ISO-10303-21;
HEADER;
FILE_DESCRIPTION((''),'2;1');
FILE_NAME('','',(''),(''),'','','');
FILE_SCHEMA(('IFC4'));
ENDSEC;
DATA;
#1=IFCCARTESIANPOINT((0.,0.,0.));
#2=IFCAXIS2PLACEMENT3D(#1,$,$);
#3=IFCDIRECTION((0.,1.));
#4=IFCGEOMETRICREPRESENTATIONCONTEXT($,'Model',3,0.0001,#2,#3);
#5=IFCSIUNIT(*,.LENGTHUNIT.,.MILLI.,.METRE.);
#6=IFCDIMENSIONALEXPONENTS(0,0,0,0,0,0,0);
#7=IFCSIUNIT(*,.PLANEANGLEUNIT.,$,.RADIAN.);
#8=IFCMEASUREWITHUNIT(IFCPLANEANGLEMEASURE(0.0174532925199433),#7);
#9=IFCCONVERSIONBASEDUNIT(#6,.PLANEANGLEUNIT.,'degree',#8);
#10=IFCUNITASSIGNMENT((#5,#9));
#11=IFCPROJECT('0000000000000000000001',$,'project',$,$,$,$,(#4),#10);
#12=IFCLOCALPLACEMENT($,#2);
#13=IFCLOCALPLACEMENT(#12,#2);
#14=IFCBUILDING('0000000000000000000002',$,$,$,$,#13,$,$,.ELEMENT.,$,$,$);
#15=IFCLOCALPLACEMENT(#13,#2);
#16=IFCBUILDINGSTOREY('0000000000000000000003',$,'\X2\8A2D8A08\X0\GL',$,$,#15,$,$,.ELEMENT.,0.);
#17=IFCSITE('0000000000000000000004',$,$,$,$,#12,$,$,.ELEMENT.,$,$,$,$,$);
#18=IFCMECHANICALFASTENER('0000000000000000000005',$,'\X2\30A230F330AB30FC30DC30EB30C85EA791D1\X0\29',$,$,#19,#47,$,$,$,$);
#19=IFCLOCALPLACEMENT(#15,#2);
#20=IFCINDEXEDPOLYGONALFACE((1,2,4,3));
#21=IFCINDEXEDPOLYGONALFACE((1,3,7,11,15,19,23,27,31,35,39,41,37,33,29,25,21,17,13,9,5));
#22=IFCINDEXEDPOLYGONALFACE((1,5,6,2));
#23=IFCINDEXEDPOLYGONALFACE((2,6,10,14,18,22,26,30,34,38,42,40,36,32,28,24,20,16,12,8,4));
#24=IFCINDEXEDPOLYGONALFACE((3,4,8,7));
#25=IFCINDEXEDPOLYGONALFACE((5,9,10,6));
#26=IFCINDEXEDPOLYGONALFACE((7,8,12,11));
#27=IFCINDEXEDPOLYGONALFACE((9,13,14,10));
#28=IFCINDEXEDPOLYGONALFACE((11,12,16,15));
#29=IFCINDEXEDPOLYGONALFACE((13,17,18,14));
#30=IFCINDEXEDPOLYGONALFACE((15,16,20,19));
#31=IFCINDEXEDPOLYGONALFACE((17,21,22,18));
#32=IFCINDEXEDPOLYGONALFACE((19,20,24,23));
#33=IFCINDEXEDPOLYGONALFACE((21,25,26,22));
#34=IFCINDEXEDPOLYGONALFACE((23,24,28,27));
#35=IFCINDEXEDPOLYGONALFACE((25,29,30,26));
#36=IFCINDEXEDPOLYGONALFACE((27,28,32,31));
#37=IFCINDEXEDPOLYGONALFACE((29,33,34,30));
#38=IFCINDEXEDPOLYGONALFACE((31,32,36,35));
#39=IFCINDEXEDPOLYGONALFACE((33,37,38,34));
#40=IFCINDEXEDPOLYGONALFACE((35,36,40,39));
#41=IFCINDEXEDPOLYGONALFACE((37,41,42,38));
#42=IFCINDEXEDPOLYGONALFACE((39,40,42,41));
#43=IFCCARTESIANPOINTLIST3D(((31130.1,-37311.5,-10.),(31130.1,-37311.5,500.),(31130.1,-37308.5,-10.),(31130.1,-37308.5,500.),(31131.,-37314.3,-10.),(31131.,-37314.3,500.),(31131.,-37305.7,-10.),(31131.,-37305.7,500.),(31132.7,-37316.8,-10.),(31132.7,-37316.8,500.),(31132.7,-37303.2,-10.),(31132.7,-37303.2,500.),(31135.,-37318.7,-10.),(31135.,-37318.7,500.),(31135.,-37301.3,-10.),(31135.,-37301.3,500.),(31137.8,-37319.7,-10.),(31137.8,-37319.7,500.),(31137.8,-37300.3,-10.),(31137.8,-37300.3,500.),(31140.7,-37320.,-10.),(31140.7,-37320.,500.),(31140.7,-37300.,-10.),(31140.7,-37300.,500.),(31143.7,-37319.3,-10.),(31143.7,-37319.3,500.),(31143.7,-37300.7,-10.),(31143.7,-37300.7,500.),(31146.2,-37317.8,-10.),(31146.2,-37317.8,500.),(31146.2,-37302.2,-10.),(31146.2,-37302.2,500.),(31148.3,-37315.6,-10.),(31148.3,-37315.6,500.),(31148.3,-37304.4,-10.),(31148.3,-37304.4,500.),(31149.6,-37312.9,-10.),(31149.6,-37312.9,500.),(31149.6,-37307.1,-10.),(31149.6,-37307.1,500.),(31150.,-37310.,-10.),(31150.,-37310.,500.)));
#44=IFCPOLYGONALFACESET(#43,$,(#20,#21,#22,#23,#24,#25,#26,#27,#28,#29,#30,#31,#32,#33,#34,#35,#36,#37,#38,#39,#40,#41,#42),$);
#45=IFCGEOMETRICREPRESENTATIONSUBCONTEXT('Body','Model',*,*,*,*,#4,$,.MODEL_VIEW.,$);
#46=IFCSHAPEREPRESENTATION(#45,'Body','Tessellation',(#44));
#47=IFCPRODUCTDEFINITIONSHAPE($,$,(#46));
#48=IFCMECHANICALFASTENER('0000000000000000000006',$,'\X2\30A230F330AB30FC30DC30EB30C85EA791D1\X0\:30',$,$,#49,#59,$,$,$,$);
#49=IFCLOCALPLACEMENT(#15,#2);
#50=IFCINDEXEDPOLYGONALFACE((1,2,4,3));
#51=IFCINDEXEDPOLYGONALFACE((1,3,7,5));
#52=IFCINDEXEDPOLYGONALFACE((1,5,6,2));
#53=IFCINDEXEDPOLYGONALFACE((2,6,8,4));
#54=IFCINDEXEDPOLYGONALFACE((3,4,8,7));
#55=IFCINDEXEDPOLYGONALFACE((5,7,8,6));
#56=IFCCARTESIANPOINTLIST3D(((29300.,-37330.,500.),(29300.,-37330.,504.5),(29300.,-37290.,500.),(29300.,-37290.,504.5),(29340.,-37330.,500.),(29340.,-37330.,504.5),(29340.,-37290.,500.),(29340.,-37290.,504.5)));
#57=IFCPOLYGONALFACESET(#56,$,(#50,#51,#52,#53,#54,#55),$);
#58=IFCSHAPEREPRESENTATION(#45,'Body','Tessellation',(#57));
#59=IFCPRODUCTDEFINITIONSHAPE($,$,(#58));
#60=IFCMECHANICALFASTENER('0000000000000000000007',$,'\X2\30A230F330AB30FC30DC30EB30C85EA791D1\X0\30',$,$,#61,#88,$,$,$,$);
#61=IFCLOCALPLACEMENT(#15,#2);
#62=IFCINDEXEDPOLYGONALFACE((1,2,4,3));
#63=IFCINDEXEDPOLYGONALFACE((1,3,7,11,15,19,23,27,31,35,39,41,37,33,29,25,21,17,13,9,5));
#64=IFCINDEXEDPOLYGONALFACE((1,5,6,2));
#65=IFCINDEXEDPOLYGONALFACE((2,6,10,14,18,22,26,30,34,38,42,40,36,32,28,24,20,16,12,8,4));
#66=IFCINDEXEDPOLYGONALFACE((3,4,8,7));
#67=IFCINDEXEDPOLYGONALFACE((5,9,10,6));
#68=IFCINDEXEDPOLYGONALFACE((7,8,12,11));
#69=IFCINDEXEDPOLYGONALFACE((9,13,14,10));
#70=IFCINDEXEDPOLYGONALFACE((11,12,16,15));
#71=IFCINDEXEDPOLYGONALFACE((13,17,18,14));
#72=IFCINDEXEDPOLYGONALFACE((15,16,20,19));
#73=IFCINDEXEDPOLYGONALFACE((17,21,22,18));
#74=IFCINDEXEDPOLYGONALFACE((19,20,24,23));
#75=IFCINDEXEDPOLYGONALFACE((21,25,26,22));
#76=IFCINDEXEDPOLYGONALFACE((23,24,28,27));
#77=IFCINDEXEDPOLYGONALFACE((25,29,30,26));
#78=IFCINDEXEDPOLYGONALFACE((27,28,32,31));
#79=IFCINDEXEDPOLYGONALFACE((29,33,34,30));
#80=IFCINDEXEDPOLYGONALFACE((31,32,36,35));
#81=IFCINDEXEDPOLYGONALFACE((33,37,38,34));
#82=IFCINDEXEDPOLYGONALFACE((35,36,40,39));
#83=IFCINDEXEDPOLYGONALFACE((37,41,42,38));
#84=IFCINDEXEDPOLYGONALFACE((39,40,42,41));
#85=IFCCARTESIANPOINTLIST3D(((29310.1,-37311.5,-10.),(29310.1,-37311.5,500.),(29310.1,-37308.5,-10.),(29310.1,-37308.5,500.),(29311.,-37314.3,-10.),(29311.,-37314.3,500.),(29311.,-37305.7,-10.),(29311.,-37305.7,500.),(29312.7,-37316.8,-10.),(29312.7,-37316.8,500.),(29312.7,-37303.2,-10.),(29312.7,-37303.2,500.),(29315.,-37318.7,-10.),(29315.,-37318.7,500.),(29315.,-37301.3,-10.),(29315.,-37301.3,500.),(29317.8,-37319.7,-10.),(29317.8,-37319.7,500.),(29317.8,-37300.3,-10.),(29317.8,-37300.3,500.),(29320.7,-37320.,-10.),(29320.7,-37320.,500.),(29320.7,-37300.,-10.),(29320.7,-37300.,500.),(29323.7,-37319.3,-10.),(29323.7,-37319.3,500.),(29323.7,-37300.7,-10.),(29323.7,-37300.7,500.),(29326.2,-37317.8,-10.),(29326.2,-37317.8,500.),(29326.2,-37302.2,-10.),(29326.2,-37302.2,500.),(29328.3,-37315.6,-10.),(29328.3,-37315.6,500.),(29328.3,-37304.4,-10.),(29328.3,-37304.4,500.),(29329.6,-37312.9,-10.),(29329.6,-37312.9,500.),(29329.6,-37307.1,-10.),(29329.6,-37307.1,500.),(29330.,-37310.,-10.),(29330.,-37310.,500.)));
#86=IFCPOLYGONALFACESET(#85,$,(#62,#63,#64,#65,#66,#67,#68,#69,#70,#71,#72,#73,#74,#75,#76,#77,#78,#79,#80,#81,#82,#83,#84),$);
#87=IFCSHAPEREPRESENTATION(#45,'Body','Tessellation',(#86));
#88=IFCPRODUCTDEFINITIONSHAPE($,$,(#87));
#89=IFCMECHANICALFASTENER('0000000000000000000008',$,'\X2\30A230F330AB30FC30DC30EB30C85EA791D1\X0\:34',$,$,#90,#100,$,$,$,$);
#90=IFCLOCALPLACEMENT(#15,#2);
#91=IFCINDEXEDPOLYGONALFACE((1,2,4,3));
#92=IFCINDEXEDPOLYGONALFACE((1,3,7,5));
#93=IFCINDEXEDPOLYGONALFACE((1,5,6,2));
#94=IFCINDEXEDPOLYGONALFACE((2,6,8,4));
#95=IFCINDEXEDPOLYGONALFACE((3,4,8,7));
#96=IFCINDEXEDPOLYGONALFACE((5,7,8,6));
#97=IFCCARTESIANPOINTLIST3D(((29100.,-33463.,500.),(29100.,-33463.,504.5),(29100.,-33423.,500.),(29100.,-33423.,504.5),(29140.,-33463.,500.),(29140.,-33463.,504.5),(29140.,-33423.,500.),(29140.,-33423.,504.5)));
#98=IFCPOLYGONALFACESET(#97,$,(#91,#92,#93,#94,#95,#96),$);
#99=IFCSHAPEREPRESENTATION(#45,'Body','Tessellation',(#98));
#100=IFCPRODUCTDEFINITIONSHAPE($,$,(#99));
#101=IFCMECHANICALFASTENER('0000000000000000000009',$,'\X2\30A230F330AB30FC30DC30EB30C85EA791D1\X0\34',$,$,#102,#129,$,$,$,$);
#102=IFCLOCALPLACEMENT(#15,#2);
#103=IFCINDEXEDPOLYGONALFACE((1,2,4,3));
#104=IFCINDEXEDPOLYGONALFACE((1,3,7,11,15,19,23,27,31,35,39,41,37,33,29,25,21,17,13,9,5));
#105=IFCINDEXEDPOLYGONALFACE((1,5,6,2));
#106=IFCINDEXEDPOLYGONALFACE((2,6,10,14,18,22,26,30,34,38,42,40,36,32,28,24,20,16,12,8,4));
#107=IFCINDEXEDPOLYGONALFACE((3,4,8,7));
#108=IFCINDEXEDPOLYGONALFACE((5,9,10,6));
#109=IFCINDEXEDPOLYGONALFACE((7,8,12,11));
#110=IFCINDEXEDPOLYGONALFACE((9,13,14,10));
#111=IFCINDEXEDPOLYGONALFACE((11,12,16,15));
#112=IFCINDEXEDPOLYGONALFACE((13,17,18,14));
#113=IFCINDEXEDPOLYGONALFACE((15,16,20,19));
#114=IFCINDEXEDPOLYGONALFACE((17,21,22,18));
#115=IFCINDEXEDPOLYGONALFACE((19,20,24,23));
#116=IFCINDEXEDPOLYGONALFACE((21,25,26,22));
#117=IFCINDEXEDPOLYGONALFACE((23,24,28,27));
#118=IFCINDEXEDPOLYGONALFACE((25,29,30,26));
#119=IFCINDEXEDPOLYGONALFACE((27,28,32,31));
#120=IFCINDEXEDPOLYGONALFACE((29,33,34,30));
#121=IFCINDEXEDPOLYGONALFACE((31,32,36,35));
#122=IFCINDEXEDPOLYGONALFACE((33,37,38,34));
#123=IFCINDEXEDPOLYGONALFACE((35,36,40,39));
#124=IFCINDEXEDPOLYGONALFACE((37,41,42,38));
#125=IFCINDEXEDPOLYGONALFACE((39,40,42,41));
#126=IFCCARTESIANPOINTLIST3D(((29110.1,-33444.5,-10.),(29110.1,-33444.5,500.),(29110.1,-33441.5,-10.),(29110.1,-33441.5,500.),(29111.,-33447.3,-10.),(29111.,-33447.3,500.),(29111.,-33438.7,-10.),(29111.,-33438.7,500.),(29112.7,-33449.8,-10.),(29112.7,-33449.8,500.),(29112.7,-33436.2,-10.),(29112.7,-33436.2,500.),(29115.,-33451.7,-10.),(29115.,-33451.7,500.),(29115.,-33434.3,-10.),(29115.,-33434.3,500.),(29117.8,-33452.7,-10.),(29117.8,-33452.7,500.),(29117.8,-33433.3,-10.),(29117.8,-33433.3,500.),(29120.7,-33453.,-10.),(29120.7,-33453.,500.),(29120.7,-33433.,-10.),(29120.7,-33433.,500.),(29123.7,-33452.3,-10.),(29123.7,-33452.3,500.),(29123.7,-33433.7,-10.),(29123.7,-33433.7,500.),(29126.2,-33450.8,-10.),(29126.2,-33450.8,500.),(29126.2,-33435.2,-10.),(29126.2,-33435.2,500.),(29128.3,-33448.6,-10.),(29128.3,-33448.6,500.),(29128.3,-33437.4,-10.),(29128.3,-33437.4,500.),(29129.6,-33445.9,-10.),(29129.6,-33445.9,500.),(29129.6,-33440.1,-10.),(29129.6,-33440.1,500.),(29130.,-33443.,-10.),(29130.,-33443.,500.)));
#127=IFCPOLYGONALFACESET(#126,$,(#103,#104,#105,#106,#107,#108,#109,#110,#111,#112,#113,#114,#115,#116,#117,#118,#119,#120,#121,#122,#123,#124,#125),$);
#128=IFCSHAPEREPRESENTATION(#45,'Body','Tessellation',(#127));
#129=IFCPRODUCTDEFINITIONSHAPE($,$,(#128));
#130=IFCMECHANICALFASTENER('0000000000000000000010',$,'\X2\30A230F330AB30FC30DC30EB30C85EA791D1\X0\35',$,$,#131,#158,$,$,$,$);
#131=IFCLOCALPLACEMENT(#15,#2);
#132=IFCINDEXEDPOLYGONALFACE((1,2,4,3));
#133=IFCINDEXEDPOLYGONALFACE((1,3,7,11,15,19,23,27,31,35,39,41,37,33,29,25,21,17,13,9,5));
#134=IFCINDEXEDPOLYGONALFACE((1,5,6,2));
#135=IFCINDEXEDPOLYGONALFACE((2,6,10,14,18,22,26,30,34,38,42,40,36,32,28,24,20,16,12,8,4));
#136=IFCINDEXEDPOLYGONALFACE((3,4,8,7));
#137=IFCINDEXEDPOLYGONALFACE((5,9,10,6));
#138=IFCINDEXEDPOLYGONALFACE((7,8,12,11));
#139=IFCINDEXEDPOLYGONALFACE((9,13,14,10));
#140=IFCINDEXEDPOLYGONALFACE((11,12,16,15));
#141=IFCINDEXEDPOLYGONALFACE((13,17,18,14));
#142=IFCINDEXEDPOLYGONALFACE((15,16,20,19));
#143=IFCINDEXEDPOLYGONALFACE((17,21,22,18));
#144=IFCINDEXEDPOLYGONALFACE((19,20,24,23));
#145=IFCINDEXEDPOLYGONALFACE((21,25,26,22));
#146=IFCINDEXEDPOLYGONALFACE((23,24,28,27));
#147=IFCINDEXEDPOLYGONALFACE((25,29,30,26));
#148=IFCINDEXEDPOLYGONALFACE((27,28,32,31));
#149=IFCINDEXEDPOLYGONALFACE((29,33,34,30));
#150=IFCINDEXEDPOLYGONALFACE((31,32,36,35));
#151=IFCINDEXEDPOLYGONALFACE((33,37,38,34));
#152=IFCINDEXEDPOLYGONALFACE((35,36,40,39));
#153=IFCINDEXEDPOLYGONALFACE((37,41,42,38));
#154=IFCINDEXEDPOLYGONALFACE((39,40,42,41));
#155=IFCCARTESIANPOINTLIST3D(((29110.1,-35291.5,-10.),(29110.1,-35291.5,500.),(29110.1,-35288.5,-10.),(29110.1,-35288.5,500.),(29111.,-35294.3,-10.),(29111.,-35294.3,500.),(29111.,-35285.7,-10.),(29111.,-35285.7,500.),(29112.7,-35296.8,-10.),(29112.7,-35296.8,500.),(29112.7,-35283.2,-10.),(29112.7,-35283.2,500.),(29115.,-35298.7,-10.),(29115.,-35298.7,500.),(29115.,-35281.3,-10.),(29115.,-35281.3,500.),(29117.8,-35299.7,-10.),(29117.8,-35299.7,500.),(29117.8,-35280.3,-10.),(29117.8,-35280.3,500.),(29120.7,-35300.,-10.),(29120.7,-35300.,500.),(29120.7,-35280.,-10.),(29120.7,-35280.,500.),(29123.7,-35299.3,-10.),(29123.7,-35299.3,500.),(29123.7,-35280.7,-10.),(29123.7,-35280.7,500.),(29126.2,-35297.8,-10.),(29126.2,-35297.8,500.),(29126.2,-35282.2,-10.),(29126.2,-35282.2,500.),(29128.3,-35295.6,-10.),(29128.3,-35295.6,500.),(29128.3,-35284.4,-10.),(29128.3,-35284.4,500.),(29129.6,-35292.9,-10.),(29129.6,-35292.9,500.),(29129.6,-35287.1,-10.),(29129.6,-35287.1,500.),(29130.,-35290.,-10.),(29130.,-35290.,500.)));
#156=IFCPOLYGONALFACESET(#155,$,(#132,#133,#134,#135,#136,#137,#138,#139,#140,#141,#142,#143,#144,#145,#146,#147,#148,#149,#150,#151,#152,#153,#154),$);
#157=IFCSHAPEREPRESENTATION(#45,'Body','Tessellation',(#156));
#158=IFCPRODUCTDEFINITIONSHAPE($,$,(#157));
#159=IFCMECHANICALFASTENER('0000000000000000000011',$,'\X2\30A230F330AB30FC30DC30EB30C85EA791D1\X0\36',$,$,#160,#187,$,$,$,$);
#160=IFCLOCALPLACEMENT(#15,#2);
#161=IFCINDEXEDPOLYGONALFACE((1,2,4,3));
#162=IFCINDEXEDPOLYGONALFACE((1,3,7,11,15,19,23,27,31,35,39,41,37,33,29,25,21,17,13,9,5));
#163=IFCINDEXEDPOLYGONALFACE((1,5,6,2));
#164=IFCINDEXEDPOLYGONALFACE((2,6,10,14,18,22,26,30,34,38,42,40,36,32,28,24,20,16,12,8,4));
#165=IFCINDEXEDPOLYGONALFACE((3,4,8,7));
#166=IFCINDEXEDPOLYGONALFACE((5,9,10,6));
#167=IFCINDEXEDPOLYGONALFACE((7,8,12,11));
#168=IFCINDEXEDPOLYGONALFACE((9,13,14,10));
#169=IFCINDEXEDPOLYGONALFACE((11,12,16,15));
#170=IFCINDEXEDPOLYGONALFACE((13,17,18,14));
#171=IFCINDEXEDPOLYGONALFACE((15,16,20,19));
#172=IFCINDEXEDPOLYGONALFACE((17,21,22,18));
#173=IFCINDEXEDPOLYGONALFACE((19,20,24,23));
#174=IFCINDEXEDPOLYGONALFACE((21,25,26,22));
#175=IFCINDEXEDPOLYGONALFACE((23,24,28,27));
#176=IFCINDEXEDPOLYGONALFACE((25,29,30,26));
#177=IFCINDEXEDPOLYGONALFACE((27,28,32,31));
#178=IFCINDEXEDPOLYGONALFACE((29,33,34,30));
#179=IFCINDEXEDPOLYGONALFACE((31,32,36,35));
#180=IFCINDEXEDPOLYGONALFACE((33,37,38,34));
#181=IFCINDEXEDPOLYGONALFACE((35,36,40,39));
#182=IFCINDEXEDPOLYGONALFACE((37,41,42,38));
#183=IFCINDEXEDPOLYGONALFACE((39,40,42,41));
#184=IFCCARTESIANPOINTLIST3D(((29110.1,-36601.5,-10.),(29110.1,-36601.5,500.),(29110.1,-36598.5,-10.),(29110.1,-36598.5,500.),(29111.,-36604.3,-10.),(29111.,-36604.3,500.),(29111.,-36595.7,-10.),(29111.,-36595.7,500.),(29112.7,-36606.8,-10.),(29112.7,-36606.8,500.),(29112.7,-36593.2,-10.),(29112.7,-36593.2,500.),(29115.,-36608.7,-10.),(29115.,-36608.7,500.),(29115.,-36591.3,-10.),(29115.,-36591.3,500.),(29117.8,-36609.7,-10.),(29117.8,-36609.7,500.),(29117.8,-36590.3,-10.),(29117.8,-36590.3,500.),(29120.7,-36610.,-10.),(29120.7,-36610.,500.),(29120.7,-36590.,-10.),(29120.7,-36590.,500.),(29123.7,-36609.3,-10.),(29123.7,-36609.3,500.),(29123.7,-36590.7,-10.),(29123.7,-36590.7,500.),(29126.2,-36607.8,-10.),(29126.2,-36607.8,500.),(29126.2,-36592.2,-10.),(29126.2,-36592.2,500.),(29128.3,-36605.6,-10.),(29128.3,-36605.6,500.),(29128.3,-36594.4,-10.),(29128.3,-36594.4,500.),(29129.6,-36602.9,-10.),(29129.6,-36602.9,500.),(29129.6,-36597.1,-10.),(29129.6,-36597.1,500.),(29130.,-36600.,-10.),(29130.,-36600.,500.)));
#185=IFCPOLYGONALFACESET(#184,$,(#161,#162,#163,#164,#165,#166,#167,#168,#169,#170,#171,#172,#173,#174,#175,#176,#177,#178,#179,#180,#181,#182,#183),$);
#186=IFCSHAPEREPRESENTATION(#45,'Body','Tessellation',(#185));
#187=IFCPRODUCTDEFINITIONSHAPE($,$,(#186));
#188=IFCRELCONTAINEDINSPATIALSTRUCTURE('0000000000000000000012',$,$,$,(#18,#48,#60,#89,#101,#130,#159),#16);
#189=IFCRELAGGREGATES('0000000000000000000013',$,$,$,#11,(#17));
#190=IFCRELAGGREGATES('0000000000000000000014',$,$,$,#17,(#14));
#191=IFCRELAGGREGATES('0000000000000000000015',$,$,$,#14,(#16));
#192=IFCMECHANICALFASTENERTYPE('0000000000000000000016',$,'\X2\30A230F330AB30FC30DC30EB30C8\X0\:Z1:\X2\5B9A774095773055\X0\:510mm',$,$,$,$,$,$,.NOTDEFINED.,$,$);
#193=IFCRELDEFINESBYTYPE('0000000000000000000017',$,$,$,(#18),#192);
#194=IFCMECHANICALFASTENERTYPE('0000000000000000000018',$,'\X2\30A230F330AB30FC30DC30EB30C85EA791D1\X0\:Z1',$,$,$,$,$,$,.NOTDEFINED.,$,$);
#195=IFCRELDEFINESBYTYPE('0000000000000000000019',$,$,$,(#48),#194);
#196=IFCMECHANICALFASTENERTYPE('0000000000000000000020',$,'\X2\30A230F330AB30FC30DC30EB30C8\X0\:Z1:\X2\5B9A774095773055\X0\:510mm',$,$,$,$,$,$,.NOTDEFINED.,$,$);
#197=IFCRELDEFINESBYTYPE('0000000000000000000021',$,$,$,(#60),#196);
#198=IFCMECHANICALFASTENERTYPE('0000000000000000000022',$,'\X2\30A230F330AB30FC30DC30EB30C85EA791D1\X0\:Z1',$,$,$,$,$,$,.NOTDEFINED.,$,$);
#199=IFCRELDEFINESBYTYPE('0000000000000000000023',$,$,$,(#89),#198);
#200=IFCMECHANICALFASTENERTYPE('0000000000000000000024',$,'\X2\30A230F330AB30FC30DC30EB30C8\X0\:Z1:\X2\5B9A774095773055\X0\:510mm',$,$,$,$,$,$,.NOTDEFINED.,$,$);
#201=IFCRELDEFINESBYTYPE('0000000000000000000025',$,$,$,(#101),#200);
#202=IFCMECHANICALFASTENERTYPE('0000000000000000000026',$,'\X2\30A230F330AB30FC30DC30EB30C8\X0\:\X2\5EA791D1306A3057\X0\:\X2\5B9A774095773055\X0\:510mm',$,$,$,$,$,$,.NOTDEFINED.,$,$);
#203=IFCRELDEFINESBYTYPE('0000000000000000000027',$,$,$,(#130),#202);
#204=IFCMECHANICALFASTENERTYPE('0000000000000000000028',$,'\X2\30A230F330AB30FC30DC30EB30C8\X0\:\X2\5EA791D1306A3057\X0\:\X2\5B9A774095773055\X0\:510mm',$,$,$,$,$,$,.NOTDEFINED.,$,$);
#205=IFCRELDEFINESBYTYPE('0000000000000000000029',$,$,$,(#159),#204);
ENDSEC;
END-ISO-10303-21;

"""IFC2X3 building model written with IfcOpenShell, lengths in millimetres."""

from ifc_helpers import new_model, entity, si_unit, converted_unit, direction, frame, origin, origin_with_axes, origin_2d, place, context, subcontext, project, spatial, rectangle, circle, extrude, type_object, element, save


model = new_model("IFC2X3")

# Units and contexts
model_context = context("Model", 3, precision=0.0001, world=origin(), true_north=direction((0.0, 1.0)))
body_context = subcontext(model_context, "Body", "Model", "MODEL_VIEW")
ifc_project = project(units=[si_unit("LENGTHUNIT", "METRE", prefix="MILLI"), converted_unit("PLANEANGLEUNIT", "degree", entity("IfcPlaneAngleMeasure", 0.0174532925199433), si_unit("PLANEANGLEUNIT", "RADIAN"), dimensions=[0, 0, 0, 0, 0, 0, 0])], contexts=[model_context])

# Site, building, storey
site_placement = place(None, origin())
site = spatial("IfcSite", under=ifc_project, at=site_placement, CompositionType="ELEMENT")
building_placement = place(site_placement, origin())
building = spatial("IfcBuilding", under=site, at=building_placement, CompositionType="ELEMENT")
storey_placement = place(building_placement, origin())
storey = spatial("IfcBuildingStorey", under=building, at=storey_placement, Name="設計GL", CompositionType="ELEMENT", Elevation=0.0)

# Mechanical fasteners
mechanical_fastener_type_1 = type_object("IfcMechanicalFastenerType", Name="アンカーボルト:Z1:定着長さ:510mm")
mechanical_fastener_1_placement = place(storey_placement, frame((31140.0, -37310.0, -10.0)))
element("IfcMechanicalFastener", 1, at=mechanical_fastener_1_placement, inside=storey, type_object=mechanical_fastener_type_1, Name="アンカーボルト座金29", context=body_context, shape_type="SweptSolid", body=[
    extrude(circle(Radius=10.0, at=origin_2d()), origin_with_axes(), (0.0, 0.0, 1.0), 510.0),
])
mechanical_fastener_type_2 = type_object("IfcMechanicalFastenerType", Name="アンカーボルト座金:Z1")
mechanical_fastener_2_placement = place(storey_placement, frame((29320.0, -37310.0, 500.0)))
element("IfcMechanicalFastener", 2, at=mechanical_fastener_2_placement, inside=storey, type_object=mechanical_fastener_type_2, Name="アンカーボルト座金:30", context=body_context, shape_type="SweptSolid", body=[
    extrude(rectangle(XDim=40.0, YDim=40.0, at=origin_2d()), origin_with_axes(), (0.0, 0.0, 1.0), 4.5),
])
mechanical_fastener_type_3 = type_object("IfcMechanicalFastenerType", Name="アンカーボルト:Z1:定着長さ:510mm")
mechanical_fastener_3_placement = place(storey_placement, frame((29320.0, -37310.0, -10.0)))
element("IfcMechanicalFastener", 3, at=mechanical_fastener_3_placement, inside=storey, type_object=mechanical_fastener_type_3, Name="アンカーボルト座金30", context=body_context, shape_type="SweptSolid", body=[
    extrude(circle(Radius=10.0, at=origin_2d()), origin_with_axes(), (0.0, 0.0, 1.0), 510.0),
])
mechanical_fastener_type_4 = type_object("IfcMechanicalFastenerType", Name="アンカーボルト座金:Z1")
mechanical_fastener_4_placement = place(storey_placement, frame((29120.0, -33443.0, 500.0)))
element("IfcMechanicalFastener", 4, at=mechanical_fastener_4_placement, inside=storey, type_object=mechanical_fastener_type_4, Name="アンカーボルト座金:34", context=body_context, shape_type="SweptSolid", body=[
    extrude(rectangle(XDim=40.0, YDim=40.0, at=origin_2d()), origin_with_axes(), (0.0, 0.0, 1.0), 4.5),
])
mechanical_fastener_type_5 = type_object("IfcMechanicalFastenerType", Name="アンカーボルト:Z1:定着長さ:510mm")
mechanical_fastener_5_placement = place(storey_placement, frame((29120.0, -33443.0, -10.0)))
element("IfcMechanicalFastener", 5, at=mechanical_fastener_5_placement, inside=storey, type_object=mechanical_fastener_type_5, Name="アンカーボルト座金34", context=body_context, shape_type="SweptSolid", body=[
    extrude(circle(Radius=10.0, at=origin_2d()), origin_with_axes(), (0.0, 0.0, 1.0), 510.0),
])
mechanical_fastener_type_6 = type_object("IfcMechanicalFastenerType", Name="アンカーボルト:座金なし:定着長さ:510mm")
mechanical_fastener_6_placement = place(storey_placement, frame((29120.0, -35290.0, -10.0)))
element("IfcMechanicalFastener", 6, at=mechanical_fastener_6_placement, inside=storey, type_object=mechanical_fastener_type_6, Name="アンカーボルト座金35", context=body_context, shape_type="SweptSolid", body=[
    extrude(circle(Radius=10.0, at=origin_2d()), origin_with_axes(), (0.0, 0.0, 1.0), 510.0),
])
mechanical_fastener_type_7 = type_object("IfcMechanicalFastenerType", Name="アンカーボルト:座金なし:定着長さ:510mm")
mechanical_fastener_7_placement = place(storey_placement, frame((29120.0, -36600.0, -10.0)))
element("IfcMechanicalFastener", 7, at=mechanical_fastener_7_placement, inside=storey, type_object=mechanical_fastener_type_7, Name="アンカーボルト座金36", context=body_context, shape_type="SweptSolid", body=[
    extrude(circle(Radius=10.0, at=origin_2d()), origin_with_axes(), (0.0, 0.0, 1.0), 510.0),
])

save(model, "model.ifc")
